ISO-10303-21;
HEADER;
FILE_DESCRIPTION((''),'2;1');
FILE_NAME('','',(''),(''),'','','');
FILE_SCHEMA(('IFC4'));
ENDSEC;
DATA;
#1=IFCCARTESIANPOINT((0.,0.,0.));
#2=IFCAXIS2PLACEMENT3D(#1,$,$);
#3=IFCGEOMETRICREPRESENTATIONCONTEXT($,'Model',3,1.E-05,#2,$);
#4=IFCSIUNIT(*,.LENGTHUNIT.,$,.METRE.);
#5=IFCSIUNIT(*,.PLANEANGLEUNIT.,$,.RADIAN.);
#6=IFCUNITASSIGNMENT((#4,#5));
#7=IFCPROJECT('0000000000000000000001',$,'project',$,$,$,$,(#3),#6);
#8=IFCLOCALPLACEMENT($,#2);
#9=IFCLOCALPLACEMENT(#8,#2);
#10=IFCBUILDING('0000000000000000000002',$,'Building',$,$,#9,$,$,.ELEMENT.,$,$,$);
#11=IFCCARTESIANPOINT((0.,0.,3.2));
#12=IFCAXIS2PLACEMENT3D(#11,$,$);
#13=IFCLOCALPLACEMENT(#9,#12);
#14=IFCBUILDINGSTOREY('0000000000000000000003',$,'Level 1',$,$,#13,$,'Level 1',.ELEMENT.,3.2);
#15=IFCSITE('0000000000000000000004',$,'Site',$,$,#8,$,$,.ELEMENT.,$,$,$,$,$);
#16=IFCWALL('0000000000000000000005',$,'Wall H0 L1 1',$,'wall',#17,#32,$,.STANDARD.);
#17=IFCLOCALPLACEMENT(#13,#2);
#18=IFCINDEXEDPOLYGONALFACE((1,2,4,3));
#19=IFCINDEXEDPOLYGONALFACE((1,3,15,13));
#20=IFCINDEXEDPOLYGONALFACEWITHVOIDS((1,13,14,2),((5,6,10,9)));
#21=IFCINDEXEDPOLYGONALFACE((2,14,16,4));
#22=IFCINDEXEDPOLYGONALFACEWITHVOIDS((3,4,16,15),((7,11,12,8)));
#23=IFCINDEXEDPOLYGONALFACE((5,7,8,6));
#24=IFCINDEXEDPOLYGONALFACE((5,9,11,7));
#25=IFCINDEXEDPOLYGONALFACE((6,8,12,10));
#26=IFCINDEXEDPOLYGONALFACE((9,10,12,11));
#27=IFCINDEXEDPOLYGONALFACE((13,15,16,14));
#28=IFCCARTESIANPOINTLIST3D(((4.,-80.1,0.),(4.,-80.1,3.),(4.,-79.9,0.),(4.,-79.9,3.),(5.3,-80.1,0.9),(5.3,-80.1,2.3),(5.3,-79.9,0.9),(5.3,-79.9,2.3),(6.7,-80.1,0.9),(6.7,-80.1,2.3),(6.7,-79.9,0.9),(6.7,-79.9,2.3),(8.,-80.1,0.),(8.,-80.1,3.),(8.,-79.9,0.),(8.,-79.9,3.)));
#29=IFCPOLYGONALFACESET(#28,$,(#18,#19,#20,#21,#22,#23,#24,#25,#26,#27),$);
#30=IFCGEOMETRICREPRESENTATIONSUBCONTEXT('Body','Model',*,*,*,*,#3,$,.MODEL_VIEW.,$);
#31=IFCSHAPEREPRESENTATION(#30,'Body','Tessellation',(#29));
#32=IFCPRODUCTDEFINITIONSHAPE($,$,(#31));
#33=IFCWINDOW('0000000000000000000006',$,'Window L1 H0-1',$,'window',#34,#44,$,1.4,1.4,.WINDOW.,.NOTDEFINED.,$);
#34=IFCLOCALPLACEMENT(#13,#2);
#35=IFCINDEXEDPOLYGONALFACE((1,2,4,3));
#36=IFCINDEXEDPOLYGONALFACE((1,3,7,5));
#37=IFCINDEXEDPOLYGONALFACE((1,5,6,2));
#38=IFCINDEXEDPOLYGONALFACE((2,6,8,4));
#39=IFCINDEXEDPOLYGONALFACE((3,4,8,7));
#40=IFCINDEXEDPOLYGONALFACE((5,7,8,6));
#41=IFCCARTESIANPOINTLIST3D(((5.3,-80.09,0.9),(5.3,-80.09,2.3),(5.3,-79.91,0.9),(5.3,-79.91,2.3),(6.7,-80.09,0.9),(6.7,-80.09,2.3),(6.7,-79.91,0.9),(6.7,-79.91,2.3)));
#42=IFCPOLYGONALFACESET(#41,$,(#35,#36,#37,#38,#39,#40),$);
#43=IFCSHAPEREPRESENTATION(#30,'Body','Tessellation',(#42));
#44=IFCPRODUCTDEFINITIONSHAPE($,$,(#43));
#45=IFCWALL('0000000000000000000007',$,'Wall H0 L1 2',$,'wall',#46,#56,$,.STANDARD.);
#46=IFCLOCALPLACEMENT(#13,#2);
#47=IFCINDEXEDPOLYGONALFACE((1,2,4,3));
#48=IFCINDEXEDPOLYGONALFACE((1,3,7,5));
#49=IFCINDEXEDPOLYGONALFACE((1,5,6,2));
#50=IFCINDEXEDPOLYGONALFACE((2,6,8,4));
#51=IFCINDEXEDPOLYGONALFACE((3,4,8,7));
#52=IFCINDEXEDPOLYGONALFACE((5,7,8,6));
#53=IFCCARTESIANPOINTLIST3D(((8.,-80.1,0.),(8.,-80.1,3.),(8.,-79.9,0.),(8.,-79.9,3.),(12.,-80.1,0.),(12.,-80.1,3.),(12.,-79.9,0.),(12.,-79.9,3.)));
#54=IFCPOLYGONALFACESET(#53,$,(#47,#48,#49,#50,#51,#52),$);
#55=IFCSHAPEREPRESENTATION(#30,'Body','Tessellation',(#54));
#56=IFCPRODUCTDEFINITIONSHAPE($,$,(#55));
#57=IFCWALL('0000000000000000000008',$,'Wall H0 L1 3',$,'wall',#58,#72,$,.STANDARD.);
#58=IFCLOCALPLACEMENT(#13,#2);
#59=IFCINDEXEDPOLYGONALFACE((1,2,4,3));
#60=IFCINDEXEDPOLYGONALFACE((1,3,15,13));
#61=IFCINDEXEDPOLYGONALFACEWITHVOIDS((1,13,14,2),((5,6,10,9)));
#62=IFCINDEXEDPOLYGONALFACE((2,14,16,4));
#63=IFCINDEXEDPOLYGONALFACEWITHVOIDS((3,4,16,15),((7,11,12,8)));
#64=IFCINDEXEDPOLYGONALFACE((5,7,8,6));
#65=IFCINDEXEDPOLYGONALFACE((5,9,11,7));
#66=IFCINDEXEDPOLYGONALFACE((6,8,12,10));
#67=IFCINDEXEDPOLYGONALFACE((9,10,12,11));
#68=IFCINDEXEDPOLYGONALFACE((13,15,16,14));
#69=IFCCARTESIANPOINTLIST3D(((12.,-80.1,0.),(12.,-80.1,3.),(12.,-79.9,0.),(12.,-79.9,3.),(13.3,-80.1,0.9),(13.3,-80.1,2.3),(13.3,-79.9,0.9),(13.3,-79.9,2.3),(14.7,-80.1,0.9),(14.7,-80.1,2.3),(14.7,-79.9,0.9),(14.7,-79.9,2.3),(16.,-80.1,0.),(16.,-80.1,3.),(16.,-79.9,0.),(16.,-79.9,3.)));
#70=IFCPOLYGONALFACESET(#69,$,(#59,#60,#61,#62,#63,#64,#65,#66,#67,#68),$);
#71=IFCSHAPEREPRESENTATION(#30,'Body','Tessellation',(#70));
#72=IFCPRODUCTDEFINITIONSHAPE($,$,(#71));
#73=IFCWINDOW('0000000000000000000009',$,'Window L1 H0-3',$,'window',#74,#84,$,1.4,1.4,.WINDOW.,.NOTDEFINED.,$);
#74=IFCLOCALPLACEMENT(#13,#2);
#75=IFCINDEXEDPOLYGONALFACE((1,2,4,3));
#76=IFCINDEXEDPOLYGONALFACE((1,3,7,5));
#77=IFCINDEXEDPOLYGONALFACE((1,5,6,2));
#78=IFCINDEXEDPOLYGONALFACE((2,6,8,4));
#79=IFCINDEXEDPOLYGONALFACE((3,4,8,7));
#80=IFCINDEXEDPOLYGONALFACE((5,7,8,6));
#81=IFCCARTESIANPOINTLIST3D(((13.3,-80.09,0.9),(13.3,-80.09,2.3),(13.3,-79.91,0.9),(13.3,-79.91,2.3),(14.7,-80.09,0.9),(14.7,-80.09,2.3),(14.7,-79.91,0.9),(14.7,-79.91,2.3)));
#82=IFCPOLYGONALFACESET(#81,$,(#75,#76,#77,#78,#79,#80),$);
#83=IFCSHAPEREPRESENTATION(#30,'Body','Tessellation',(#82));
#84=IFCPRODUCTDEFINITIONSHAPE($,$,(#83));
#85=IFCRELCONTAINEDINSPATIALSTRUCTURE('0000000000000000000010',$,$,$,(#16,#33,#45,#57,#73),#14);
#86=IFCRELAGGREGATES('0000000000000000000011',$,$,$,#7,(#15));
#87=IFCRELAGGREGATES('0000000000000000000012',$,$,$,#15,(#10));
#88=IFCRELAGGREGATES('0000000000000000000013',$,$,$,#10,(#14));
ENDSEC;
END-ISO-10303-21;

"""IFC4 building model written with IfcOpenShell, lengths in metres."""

from ifc_helpers import new_model, si_unit, frame, frame_2d, origin, origin_2d, place, context, subcontext, project, spatial, rectangle, extrude, element, fill, save


model = new_model("IFC4")

# Units and contexts
model_context = context("Model", 3, precision=1e-05, world=origin())
body_context = subcontext(model_context, "Body", "Model", "MODEL_VIEW")
ifc_project = project(units=[si_unit("LENGTHUNIT", "METRE"), si_unit("PLANEANGLEUNIT", "RADIAN")], contexts=[model_context])

# Site, building, storey
site_placement = place(None, origin())
site = spatial("IfcSite", under=ifc_project, at=site_placement, Name="Site", CompositionType="ELEMENT")
building_placement = place(site_placement, origin())
building = spatial("IfcBuilding", under=site, at=building_placement, Name="Building", CompositionType="ELEMENT")
storey_placement = place(building_placement, frame((0.0, 0.0, 3.2)))
storey = spatial("IfcBuildingStorey", under=building, at=storey_placement, Name="Level 1", LongName="Level 1", CompositionType="ELEMENT", Elevation=3.2)

# Wall, opening, window
wall_1_placement = place(storey_placement, frame((4.0, -80.0, 0.0), z_axis=(0.0, 0.0, 1.0), x_axis=(1.0, 0.0, 0.0)))
wall_1 = element("IfcWall", 1, at=wall_1_placement, inside=storey, Name="Wall H0 L1 1", ObjectType="wall", PredefinedType="STANDARD", context=body_context, shape_type="SweptSolid", body=[
    extrude(rectangle(XDim=4.0, YDim=0.2, at=frame_2d((2.0, 0.0))), origin(), (0.0, 0.0, 1.0), 3.0),
])
opening_1_placement = place(storey_placement, frame((6.0, -80.0, 0.9), z_axis=(0.0, 0.0, 1.0), x_axis=(1.0, 0.0, 0.0)))
opening_1 = element("IfcOpeningElement", 2, at=opening_1_placement, cuts=wall_1, ObjectType="Opening", PredefinedType="OPENING", context=body_context, shape_type="SweptSolid", body=[
    extrude(rectangle(XDim=1.4, YDim=0.22, at=origin_2d()), origin(), (0.0, 0.0, 1.0), 1.4),
])
window_1_placement = place(storey_placement, frame((6.0, -80.0, 0.9), z_axis=(0.0, 0.0, 1.0), x_axis=(1.0, 0.0, 0.0)))
window_1 = element("IfcWindow", 3, at=window_1_placement, inside=storey, Name="Window L1 H0-1", ObjectType="window", OverallHeight=1.4, OverallWidth=1.4, PartitioningType="NOTDEFINED", PredefinedType="WINDOW", context=body_context, shape_type="SweptSolid", body=[
    extrude(rectangle(XDim=1.4, YDim=0.18, at=origin_2d()), origin(), (0.0, 0.0, 1.0), 1.4),
])
fill(opening_1, window_1)

# Wall
wall_2_placement = place(storey_placement, frame((8.0, -80.0, 0.0), z_axis=(0.0, 0.0, 1.0), x_axis=(1.0, 0.0, 0.0)))
element("IfcWall", 4, at=wall_2_placement, inside=storey, Name="Wall H0 L1 2", ObjectType="wall", PredefinedType="STANDARD", context=body_context, shape_type="SweptSolid", body=[
    extrude(rectangle(XDim=4.0, YDim=0.2, at=frame_2d((2.0, 0.0))), origin(), (0.0, 0.0, 1.0), 3.0),
])

# Wall, opening, window
wall_3_placement = place(storey_placement, frame((12.0, -80.0, 0.0), z_axis=(0.0, 0.0, 1.0), x_axis=(1.0, 0.0, 0.0)))
wall_3 = element("IfcWall", 5, at=wall_3_placement, inside=storey, Name="Wall H0 L1 3", ObjectType="wall", PredefinedType="STANDARD", context=body_context, shape_type="SweptSolid", body=[
    extrude(rectangle(XDim=4.0, YDim=0.2, at=frame_2d((2.0, 0.0))), origin(), (0.0, 0.0, 1.0), 3.0),
])
opening_2_placement = place(storey_placement, frame((14.0, -80.0, 0.9), z_axis=(0.0, 0.0, 1.0), x_axis=(1.0, 0.0, 0.0)))
opening_2 = element("IfcOpeningElement", 6, at=opening_2_placement, cuts=wall_3, ObjectType="Opening", PredefinedType="OPENING", context=body_context, shape_type="SweptSolid", body=[
    extrude(rectangle(XDim=1.4, YDim=0.22, at=origin_2d()), origin(), (0.0, 0.0, 1.0), 1.4),
])
window_2_placement = place(storey_placement, frame((14.0, -80.0, 0.9), z_axis=(0.0, 0.0, 1.0), x_axis=(1.0, 0.0, 0.0)))
window_2 = element("IfcWindow", 7, at=window_2_placement, inside=storey, Name="Window L1 H0-3", ObjectType="window", OverallHeight=1.4, OverallWidth=1.4, PartitioningType="NOTDEFINED", PredefinedType="WINDOW", context=body_context, shape_type="SweptSolid", body=[
    extrude(rectangle(XDim=1.4, YDim=0.18, at=origin_2d()), origin(), (0.0, 0.0, 1.0), 1.4),
])
fill(opening_2, window_2)

save(model, "model.ifc")
